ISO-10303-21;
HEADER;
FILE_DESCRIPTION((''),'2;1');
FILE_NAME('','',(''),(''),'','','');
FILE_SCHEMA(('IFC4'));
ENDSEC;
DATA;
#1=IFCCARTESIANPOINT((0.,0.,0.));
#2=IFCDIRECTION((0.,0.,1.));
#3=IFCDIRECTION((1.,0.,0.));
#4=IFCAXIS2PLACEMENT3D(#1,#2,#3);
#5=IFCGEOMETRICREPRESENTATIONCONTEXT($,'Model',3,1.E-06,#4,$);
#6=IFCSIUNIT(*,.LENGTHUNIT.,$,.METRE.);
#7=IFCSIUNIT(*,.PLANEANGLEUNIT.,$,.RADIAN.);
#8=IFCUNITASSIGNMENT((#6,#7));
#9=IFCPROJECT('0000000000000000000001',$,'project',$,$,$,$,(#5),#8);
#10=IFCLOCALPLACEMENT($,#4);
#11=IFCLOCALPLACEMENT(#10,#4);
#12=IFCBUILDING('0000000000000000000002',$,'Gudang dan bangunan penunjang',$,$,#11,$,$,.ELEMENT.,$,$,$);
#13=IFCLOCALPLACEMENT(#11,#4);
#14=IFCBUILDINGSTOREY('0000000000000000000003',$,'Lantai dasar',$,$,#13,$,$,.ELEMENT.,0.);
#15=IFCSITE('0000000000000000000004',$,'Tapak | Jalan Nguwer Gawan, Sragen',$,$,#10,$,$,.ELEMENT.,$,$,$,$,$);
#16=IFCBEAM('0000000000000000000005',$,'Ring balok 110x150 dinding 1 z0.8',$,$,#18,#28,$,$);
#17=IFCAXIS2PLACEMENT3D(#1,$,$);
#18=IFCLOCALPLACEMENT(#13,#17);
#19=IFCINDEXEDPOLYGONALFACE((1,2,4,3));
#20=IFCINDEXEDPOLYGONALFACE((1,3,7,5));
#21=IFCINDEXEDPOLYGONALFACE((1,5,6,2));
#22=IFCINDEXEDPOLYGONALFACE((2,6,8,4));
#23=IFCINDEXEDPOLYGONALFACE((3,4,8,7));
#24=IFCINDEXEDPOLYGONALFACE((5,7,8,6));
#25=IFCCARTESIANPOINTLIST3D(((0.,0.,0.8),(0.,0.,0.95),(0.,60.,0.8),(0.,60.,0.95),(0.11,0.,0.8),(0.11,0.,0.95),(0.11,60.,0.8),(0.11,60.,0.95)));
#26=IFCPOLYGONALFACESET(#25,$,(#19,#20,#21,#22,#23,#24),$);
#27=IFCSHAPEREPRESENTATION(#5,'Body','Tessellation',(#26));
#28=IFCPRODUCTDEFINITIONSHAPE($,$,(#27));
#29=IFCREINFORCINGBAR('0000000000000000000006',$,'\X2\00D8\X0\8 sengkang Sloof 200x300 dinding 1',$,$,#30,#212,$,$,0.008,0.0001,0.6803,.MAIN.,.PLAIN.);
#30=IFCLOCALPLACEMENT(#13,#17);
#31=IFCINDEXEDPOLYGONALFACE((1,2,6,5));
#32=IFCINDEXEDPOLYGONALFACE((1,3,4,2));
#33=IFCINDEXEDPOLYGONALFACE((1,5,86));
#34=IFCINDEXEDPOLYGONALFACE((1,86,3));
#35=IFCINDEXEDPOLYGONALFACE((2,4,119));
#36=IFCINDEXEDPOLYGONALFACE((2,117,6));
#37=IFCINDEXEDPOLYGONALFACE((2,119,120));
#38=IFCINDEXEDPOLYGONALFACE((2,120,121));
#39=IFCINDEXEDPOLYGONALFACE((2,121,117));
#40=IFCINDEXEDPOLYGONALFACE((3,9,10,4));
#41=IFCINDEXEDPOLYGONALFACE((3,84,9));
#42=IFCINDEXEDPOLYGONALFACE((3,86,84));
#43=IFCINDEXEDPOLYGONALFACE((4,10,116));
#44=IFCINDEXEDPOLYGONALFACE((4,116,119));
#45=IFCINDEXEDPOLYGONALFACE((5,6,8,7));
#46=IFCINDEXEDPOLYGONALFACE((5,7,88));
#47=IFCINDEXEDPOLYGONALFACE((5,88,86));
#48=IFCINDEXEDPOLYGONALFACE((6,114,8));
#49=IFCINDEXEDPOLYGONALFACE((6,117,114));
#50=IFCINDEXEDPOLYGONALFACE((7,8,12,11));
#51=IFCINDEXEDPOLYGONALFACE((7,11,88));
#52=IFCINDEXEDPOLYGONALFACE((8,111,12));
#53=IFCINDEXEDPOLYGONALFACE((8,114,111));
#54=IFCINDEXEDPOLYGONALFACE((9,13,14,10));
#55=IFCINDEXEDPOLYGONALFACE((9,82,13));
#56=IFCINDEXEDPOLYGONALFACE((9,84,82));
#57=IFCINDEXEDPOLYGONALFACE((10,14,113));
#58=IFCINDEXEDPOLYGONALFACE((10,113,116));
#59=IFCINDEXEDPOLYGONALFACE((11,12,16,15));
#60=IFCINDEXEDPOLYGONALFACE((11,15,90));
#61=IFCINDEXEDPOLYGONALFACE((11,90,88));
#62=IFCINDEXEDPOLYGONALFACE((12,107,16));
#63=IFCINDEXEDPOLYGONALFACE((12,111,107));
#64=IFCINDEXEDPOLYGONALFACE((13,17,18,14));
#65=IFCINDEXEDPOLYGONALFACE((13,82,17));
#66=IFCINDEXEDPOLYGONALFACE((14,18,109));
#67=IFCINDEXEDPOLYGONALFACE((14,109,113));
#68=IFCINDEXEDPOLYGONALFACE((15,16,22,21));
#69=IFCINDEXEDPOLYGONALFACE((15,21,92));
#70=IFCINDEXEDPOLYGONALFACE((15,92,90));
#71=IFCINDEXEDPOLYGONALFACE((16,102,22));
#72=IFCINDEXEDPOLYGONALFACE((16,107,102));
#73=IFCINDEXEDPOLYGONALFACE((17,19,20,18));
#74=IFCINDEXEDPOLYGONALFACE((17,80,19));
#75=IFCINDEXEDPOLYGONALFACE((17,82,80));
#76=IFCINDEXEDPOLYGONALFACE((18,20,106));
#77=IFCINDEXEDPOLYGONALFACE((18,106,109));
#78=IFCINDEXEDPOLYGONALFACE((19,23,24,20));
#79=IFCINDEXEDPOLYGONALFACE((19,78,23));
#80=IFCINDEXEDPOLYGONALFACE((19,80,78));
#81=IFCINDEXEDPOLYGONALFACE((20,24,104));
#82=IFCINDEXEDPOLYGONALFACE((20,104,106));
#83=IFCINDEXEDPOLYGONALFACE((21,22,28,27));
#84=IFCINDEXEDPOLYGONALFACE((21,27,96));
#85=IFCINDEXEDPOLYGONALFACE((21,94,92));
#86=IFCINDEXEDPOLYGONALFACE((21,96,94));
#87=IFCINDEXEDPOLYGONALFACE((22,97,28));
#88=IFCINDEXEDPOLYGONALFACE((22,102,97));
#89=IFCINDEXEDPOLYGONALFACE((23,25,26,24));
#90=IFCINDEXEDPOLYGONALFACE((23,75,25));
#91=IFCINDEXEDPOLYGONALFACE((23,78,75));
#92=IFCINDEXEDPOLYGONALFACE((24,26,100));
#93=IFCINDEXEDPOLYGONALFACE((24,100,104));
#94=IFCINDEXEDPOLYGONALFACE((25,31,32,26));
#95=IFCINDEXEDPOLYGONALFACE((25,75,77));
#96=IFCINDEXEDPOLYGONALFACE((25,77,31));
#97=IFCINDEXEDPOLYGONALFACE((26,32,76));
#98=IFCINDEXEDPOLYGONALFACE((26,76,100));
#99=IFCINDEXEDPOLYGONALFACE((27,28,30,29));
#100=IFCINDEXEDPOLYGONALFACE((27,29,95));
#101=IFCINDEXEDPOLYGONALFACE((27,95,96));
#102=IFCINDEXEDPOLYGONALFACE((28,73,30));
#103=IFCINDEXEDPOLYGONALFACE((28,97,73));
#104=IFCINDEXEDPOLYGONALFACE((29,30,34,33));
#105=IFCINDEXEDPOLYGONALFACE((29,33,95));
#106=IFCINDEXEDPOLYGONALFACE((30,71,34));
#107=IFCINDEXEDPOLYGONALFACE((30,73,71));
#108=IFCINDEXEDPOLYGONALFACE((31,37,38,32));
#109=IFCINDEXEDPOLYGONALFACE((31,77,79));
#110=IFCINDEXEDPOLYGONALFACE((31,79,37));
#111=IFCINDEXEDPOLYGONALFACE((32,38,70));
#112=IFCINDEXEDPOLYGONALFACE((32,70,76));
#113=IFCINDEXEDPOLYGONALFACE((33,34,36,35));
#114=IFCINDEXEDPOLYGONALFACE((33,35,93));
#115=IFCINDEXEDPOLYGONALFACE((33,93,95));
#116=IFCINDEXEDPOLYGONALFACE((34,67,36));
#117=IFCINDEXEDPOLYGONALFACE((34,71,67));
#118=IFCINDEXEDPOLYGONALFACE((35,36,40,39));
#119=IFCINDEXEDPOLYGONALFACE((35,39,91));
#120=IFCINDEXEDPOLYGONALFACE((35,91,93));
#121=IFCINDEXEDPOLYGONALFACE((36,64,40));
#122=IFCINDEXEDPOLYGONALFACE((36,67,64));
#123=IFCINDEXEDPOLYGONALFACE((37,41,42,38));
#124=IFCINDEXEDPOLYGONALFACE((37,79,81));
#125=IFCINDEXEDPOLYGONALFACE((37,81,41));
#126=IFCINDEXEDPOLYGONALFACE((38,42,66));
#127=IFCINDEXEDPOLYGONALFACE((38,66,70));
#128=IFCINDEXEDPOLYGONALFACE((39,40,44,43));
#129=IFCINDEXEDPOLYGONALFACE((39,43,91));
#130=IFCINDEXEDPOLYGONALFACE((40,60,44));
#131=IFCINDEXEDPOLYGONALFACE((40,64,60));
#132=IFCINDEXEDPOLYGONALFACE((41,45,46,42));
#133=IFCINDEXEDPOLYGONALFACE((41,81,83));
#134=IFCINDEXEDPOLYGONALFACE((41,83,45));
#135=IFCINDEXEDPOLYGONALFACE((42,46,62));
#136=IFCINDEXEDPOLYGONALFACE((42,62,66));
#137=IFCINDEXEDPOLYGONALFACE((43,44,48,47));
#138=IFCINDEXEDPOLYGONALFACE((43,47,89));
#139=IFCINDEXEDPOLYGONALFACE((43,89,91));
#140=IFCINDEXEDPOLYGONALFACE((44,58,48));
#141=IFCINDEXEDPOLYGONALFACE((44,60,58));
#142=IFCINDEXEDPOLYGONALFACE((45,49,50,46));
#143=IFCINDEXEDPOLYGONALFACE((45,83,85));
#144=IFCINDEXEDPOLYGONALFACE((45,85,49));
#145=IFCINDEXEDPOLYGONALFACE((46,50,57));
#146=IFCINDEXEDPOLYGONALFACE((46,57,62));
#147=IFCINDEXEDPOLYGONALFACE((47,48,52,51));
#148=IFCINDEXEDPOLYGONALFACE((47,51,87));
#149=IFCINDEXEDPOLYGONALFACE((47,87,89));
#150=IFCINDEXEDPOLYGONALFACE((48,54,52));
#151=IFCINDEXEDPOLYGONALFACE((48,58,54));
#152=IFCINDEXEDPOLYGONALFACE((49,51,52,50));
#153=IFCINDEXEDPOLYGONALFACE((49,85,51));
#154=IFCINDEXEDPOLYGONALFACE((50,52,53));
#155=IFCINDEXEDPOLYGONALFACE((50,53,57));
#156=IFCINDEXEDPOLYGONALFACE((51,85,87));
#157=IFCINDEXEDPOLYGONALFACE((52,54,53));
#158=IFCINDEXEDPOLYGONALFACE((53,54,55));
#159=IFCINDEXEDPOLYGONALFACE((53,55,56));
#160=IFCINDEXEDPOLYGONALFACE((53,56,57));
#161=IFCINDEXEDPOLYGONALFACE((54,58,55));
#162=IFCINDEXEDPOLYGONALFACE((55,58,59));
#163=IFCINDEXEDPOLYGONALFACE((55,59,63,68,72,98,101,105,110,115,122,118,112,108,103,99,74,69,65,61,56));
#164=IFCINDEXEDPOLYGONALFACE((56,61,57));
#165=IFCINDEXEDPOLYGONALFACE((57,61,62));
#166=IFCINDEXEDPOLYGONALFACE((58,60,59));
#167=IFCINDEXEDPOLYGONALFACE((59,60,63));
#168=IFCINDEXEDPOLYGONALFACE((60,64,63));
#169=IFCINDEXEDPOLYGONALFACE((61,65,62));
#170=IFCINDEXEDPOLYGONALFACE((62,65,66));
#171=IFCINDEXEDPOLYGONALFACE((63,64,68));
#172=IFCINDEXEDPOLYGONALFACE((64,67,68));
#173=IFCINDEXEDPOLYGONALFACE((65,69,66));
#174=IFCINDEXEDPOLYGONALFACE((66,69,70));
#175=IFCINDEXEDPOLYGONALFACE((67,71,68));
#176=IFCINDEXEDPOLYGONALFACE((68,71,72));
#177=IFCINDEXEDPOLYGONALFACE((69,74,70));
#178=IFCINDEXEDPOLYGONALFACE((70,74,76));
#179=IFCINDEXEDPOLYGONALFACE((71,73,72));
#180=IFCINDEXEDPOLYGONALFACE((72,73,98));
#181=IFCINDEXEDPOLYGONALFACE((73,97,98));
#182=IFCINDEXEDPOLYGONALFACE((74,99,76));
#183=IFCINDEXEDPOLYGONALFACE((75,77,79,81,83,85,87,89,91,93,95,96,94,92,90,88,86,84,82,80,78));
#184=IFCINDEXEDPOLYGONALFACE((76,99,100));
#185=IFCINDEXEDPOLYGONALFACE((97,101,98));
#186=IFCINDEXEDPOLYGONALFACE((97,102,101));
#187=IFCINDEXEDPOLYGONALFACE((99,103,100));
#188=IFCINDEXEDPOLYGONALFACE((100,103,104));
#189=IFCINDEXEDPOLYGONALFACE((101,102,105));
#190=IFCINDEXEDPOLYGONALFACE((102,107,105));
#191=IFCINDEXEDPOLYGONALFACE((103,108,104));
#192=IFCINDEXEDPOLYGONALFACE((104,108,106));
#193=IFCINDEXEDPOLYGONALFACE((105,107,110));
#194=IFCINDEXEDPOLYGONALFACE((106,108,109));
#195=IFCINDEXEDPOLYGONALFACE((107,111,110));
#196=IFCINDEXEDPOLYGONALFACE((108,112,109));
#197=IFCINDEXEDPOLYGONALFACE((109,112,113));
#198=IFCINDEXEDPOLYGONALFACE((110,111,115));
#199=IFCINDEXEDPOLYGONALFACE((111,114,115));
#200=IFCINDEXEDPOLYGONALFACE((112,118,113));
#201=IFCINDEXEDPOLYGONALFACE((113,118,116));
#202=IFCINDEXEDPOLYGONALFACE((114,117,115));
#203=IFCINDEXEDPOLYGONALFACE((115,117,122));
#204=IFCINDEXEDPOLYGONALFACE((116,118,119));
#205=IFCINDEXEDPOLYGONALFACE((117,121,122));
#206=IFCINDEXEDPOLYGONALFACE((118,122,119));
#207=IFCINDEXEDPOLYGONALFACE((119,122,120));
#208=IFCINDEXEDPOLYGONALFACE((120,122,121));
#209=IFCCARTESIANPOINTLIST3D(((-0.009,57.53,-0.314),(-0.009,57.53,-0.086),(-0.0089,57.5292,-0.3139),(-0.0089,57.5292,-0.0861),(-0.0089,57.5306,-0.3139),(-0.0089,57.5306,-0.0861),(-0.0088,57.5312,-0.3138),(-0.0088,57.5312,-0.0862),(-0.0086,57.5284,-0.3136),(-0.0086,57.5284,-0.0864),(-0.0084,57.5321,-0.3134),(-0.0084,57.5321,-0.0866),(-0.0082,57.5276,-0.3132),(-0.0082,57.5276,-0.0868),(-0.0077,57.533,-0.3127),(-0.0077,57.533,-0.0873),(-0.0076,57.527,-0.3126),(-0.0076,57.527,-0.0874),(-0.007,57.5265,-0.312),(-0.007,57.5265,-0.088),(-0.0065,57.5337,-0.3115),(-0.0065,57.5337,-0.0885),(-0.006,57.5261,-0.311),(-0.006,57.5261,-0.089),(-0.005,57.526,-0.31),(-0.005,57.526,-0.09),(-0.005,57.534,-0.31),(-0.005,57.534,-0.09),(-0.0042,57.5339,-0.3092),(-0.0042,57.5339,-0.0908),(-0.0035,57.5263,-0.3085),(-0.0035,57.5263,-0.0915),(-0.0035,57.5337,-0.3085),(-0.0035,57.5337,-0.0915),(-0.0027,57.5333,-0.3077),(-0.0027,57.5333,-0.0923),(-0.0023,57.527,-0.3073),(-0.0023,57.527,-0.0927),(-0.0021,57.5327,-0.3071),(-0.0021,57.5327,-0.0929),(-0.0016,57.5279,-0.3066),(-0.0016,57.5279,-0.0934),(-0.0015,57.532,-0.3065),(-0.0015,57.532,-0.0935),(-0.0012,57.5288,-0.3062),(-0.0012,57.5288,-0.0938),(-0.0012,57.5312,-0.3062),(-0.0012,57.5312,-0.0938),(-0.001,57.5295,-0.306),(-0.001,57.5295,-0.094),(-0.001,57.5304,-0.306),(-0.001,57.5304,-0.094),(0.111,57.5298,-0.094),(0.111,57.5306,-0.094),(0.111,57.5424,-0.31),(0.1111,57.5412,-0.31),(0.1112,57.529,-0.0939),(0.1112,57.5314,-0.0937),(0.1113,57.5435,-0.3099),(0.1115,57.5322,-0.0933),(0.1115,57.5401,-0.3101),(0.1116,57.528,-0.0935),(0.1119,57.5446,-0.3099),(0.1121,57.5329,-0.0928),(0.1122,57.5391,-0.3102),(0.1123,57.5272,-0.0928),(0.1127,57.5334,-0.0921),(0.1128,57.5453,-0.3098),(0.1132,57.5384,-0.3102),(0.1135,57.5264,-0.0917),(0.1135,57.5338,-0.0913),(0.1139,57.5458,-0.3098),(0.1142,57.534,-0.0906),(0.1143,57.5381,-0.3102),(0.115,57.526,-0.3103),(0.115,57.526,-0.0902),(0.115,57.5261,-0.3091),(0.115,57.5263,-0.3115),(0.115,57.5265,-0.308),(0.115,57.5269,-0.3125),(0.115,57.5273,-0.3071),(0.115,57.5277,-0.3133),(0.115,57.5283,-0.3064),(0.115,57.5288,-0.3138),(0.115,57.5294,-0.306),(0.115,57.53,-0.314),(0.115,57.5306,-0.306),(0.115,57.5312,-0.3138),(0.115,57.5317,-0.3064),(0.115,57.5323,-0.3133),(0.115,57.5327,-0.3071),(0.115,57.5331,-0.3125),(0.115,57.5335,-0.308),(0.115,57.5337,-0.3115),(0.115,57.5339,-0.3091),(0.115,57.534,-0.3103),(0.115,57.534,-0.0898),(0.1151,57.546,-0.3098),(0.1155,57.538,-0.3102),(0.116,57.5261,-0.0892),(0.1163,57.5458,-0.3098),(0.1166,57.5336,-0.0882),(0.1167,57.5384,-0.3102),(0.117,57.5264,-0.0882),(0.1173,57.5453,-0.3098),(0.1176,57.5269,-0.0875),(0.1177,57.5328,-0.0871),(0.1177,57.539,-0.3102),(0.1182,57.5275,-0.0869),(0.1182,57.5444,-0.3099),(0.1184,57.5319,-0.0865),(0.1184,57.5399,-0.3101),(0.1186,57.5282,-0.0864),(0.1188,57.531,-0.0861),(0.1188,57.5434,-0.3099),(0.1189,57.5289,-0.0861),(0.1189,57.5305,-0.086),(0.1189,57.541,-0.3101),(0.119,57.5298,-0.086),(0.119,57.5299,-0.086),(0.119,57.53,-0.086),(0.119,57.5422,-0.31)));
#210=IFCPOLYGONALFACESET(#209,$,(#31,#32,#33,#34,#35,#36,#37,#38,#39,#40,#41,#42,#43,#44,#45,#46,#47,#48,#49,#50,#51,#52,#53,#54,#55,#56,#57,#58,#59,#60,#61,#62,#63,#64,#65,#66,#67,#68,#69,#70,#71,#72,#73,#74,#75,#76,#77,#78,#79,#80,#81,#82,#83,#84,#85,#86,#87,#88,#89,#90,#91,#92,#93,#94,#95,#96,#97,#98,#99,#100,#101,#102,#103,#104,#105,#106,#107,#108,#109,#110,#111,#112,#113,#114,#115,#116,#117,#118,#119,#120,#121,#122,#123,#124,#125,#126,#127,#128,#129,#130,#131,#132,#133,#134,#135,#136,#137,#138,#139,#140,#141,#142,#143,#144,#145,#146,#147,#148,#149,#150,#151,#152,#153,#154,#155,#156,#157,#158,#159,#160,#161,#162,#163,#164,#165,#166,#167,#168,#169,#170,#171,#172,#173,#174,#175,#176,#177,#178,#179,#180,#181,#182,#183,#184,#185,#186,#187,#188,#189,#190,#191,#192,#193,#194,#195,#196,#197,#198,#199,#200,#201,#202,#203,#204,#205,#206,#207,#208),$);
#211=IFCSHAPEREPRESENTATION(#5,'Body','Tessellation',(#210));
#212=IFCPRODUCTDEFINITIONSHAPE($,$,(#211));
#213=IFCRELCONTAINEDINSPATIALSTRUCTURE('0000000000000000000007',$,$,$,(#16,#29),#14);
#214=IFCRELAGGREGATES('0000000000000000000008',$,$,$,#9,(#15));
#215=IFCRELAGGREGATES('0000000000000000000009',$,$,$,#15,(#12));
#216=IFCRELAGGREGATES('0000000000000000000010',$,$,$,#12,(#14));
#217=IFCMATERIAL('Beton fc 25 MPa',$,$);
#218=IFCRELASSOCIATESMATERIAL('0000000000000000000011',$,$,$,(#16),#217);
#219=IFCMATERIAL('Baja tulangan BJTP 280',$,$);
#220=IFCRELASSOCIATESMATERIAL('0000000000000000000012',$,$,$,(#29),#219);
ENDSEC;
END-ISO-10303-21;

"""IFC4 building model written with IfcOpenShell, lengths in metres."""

from ifc_helpers import new_model, entity, si_unit, frame, origin_with_axes, place, context, project, spatial, rectangle, extrude, material, element, save


model = new_model("IFC4")

# Units and contexts
model_context = context("Model", 3, precision=1e-06, world=origin_with_axes())
ifc_project = project(units=[si_unit("LENGTHUNIT", "METRE"), si_unit("PLANEANGLEUNIT", "RADIAN")], contexts=[model_context])

# Site, building, storey
site_placement = place(None, origin_with_axes())
site = spatial("IfcSite", under=ifc_project, at=site_placement, Name="Tapak | Jalan Nguwer Gawan, Sragen", CompositionType="ELEMENT")
building_placement = place(site_placement, origin_with_axes())
building = spatial("IfcBuilding", under=site, at=building_placement, Name="Gudang dan bangunan penunjang", CompositionType="ELEMENT")
storey_placement = place(building_placement, origin_with_axes())
storey = spatial("IfcBuildingStorey", under=building, at=storey_placement, Name="Lantai dasar", CompositionType="ELEMENT", Elevation=0.0)

# Beam
ifc_material_1 = material(Name="Beton fc 25 MPa")
placement = place(None, origin_with_axes())
element("IfcBeam", 1, at=placement, inside=storey, material=ifc_material_1, Name="Ring balok 110x150 dinding 1 z0.8", context=model_context, shape_type="SweptSolid", body=[
    extrude(rectangle(XDim=0.11, YDim=0.15), frame((0.055, 0.0, 0.875), z_axis=(0.0, 1.0, 0.0), x_axis=(-1.0, 0.0, 0.0)), (0.0, 0.0, 1.0), 60.0),
])

# Reinforcing bar
ifc_material_2 = material(Name="Baja tulangan BJTP 280")
element("IfcReinforcingBar", 2, at=placement, inside=storey, material=ifc_material_2, Name="Ø8 sengkang Sloof 200x300 dinding 1", BarLength=0.6803, BarSurface="PLAIN", CrossSectionArea=0.0001, NominalDiameter=0.008, PredefinedType="MAIN", context=model_context, shape_type="AdvancedSweptSolid", body=[
    entity("IfcSweptDiskSolid", entity("IfcPolyline", [entity("IfcCartesianPoint", [0.115, 57.53, -0.31]), entity("IfcCartesianPoint", [-0.005, 57.53, -0.31]), entity("IfcCartesianPoint", [-0.005, 57.53, -0.09]), entity("IfcCartesianPoint", [0.115, 57.53, -0.09]), entity("IfcCartesianPoint", [0.115, 57.542, -0.31])]), 0.004),
])

save(model, "model.ifc")
